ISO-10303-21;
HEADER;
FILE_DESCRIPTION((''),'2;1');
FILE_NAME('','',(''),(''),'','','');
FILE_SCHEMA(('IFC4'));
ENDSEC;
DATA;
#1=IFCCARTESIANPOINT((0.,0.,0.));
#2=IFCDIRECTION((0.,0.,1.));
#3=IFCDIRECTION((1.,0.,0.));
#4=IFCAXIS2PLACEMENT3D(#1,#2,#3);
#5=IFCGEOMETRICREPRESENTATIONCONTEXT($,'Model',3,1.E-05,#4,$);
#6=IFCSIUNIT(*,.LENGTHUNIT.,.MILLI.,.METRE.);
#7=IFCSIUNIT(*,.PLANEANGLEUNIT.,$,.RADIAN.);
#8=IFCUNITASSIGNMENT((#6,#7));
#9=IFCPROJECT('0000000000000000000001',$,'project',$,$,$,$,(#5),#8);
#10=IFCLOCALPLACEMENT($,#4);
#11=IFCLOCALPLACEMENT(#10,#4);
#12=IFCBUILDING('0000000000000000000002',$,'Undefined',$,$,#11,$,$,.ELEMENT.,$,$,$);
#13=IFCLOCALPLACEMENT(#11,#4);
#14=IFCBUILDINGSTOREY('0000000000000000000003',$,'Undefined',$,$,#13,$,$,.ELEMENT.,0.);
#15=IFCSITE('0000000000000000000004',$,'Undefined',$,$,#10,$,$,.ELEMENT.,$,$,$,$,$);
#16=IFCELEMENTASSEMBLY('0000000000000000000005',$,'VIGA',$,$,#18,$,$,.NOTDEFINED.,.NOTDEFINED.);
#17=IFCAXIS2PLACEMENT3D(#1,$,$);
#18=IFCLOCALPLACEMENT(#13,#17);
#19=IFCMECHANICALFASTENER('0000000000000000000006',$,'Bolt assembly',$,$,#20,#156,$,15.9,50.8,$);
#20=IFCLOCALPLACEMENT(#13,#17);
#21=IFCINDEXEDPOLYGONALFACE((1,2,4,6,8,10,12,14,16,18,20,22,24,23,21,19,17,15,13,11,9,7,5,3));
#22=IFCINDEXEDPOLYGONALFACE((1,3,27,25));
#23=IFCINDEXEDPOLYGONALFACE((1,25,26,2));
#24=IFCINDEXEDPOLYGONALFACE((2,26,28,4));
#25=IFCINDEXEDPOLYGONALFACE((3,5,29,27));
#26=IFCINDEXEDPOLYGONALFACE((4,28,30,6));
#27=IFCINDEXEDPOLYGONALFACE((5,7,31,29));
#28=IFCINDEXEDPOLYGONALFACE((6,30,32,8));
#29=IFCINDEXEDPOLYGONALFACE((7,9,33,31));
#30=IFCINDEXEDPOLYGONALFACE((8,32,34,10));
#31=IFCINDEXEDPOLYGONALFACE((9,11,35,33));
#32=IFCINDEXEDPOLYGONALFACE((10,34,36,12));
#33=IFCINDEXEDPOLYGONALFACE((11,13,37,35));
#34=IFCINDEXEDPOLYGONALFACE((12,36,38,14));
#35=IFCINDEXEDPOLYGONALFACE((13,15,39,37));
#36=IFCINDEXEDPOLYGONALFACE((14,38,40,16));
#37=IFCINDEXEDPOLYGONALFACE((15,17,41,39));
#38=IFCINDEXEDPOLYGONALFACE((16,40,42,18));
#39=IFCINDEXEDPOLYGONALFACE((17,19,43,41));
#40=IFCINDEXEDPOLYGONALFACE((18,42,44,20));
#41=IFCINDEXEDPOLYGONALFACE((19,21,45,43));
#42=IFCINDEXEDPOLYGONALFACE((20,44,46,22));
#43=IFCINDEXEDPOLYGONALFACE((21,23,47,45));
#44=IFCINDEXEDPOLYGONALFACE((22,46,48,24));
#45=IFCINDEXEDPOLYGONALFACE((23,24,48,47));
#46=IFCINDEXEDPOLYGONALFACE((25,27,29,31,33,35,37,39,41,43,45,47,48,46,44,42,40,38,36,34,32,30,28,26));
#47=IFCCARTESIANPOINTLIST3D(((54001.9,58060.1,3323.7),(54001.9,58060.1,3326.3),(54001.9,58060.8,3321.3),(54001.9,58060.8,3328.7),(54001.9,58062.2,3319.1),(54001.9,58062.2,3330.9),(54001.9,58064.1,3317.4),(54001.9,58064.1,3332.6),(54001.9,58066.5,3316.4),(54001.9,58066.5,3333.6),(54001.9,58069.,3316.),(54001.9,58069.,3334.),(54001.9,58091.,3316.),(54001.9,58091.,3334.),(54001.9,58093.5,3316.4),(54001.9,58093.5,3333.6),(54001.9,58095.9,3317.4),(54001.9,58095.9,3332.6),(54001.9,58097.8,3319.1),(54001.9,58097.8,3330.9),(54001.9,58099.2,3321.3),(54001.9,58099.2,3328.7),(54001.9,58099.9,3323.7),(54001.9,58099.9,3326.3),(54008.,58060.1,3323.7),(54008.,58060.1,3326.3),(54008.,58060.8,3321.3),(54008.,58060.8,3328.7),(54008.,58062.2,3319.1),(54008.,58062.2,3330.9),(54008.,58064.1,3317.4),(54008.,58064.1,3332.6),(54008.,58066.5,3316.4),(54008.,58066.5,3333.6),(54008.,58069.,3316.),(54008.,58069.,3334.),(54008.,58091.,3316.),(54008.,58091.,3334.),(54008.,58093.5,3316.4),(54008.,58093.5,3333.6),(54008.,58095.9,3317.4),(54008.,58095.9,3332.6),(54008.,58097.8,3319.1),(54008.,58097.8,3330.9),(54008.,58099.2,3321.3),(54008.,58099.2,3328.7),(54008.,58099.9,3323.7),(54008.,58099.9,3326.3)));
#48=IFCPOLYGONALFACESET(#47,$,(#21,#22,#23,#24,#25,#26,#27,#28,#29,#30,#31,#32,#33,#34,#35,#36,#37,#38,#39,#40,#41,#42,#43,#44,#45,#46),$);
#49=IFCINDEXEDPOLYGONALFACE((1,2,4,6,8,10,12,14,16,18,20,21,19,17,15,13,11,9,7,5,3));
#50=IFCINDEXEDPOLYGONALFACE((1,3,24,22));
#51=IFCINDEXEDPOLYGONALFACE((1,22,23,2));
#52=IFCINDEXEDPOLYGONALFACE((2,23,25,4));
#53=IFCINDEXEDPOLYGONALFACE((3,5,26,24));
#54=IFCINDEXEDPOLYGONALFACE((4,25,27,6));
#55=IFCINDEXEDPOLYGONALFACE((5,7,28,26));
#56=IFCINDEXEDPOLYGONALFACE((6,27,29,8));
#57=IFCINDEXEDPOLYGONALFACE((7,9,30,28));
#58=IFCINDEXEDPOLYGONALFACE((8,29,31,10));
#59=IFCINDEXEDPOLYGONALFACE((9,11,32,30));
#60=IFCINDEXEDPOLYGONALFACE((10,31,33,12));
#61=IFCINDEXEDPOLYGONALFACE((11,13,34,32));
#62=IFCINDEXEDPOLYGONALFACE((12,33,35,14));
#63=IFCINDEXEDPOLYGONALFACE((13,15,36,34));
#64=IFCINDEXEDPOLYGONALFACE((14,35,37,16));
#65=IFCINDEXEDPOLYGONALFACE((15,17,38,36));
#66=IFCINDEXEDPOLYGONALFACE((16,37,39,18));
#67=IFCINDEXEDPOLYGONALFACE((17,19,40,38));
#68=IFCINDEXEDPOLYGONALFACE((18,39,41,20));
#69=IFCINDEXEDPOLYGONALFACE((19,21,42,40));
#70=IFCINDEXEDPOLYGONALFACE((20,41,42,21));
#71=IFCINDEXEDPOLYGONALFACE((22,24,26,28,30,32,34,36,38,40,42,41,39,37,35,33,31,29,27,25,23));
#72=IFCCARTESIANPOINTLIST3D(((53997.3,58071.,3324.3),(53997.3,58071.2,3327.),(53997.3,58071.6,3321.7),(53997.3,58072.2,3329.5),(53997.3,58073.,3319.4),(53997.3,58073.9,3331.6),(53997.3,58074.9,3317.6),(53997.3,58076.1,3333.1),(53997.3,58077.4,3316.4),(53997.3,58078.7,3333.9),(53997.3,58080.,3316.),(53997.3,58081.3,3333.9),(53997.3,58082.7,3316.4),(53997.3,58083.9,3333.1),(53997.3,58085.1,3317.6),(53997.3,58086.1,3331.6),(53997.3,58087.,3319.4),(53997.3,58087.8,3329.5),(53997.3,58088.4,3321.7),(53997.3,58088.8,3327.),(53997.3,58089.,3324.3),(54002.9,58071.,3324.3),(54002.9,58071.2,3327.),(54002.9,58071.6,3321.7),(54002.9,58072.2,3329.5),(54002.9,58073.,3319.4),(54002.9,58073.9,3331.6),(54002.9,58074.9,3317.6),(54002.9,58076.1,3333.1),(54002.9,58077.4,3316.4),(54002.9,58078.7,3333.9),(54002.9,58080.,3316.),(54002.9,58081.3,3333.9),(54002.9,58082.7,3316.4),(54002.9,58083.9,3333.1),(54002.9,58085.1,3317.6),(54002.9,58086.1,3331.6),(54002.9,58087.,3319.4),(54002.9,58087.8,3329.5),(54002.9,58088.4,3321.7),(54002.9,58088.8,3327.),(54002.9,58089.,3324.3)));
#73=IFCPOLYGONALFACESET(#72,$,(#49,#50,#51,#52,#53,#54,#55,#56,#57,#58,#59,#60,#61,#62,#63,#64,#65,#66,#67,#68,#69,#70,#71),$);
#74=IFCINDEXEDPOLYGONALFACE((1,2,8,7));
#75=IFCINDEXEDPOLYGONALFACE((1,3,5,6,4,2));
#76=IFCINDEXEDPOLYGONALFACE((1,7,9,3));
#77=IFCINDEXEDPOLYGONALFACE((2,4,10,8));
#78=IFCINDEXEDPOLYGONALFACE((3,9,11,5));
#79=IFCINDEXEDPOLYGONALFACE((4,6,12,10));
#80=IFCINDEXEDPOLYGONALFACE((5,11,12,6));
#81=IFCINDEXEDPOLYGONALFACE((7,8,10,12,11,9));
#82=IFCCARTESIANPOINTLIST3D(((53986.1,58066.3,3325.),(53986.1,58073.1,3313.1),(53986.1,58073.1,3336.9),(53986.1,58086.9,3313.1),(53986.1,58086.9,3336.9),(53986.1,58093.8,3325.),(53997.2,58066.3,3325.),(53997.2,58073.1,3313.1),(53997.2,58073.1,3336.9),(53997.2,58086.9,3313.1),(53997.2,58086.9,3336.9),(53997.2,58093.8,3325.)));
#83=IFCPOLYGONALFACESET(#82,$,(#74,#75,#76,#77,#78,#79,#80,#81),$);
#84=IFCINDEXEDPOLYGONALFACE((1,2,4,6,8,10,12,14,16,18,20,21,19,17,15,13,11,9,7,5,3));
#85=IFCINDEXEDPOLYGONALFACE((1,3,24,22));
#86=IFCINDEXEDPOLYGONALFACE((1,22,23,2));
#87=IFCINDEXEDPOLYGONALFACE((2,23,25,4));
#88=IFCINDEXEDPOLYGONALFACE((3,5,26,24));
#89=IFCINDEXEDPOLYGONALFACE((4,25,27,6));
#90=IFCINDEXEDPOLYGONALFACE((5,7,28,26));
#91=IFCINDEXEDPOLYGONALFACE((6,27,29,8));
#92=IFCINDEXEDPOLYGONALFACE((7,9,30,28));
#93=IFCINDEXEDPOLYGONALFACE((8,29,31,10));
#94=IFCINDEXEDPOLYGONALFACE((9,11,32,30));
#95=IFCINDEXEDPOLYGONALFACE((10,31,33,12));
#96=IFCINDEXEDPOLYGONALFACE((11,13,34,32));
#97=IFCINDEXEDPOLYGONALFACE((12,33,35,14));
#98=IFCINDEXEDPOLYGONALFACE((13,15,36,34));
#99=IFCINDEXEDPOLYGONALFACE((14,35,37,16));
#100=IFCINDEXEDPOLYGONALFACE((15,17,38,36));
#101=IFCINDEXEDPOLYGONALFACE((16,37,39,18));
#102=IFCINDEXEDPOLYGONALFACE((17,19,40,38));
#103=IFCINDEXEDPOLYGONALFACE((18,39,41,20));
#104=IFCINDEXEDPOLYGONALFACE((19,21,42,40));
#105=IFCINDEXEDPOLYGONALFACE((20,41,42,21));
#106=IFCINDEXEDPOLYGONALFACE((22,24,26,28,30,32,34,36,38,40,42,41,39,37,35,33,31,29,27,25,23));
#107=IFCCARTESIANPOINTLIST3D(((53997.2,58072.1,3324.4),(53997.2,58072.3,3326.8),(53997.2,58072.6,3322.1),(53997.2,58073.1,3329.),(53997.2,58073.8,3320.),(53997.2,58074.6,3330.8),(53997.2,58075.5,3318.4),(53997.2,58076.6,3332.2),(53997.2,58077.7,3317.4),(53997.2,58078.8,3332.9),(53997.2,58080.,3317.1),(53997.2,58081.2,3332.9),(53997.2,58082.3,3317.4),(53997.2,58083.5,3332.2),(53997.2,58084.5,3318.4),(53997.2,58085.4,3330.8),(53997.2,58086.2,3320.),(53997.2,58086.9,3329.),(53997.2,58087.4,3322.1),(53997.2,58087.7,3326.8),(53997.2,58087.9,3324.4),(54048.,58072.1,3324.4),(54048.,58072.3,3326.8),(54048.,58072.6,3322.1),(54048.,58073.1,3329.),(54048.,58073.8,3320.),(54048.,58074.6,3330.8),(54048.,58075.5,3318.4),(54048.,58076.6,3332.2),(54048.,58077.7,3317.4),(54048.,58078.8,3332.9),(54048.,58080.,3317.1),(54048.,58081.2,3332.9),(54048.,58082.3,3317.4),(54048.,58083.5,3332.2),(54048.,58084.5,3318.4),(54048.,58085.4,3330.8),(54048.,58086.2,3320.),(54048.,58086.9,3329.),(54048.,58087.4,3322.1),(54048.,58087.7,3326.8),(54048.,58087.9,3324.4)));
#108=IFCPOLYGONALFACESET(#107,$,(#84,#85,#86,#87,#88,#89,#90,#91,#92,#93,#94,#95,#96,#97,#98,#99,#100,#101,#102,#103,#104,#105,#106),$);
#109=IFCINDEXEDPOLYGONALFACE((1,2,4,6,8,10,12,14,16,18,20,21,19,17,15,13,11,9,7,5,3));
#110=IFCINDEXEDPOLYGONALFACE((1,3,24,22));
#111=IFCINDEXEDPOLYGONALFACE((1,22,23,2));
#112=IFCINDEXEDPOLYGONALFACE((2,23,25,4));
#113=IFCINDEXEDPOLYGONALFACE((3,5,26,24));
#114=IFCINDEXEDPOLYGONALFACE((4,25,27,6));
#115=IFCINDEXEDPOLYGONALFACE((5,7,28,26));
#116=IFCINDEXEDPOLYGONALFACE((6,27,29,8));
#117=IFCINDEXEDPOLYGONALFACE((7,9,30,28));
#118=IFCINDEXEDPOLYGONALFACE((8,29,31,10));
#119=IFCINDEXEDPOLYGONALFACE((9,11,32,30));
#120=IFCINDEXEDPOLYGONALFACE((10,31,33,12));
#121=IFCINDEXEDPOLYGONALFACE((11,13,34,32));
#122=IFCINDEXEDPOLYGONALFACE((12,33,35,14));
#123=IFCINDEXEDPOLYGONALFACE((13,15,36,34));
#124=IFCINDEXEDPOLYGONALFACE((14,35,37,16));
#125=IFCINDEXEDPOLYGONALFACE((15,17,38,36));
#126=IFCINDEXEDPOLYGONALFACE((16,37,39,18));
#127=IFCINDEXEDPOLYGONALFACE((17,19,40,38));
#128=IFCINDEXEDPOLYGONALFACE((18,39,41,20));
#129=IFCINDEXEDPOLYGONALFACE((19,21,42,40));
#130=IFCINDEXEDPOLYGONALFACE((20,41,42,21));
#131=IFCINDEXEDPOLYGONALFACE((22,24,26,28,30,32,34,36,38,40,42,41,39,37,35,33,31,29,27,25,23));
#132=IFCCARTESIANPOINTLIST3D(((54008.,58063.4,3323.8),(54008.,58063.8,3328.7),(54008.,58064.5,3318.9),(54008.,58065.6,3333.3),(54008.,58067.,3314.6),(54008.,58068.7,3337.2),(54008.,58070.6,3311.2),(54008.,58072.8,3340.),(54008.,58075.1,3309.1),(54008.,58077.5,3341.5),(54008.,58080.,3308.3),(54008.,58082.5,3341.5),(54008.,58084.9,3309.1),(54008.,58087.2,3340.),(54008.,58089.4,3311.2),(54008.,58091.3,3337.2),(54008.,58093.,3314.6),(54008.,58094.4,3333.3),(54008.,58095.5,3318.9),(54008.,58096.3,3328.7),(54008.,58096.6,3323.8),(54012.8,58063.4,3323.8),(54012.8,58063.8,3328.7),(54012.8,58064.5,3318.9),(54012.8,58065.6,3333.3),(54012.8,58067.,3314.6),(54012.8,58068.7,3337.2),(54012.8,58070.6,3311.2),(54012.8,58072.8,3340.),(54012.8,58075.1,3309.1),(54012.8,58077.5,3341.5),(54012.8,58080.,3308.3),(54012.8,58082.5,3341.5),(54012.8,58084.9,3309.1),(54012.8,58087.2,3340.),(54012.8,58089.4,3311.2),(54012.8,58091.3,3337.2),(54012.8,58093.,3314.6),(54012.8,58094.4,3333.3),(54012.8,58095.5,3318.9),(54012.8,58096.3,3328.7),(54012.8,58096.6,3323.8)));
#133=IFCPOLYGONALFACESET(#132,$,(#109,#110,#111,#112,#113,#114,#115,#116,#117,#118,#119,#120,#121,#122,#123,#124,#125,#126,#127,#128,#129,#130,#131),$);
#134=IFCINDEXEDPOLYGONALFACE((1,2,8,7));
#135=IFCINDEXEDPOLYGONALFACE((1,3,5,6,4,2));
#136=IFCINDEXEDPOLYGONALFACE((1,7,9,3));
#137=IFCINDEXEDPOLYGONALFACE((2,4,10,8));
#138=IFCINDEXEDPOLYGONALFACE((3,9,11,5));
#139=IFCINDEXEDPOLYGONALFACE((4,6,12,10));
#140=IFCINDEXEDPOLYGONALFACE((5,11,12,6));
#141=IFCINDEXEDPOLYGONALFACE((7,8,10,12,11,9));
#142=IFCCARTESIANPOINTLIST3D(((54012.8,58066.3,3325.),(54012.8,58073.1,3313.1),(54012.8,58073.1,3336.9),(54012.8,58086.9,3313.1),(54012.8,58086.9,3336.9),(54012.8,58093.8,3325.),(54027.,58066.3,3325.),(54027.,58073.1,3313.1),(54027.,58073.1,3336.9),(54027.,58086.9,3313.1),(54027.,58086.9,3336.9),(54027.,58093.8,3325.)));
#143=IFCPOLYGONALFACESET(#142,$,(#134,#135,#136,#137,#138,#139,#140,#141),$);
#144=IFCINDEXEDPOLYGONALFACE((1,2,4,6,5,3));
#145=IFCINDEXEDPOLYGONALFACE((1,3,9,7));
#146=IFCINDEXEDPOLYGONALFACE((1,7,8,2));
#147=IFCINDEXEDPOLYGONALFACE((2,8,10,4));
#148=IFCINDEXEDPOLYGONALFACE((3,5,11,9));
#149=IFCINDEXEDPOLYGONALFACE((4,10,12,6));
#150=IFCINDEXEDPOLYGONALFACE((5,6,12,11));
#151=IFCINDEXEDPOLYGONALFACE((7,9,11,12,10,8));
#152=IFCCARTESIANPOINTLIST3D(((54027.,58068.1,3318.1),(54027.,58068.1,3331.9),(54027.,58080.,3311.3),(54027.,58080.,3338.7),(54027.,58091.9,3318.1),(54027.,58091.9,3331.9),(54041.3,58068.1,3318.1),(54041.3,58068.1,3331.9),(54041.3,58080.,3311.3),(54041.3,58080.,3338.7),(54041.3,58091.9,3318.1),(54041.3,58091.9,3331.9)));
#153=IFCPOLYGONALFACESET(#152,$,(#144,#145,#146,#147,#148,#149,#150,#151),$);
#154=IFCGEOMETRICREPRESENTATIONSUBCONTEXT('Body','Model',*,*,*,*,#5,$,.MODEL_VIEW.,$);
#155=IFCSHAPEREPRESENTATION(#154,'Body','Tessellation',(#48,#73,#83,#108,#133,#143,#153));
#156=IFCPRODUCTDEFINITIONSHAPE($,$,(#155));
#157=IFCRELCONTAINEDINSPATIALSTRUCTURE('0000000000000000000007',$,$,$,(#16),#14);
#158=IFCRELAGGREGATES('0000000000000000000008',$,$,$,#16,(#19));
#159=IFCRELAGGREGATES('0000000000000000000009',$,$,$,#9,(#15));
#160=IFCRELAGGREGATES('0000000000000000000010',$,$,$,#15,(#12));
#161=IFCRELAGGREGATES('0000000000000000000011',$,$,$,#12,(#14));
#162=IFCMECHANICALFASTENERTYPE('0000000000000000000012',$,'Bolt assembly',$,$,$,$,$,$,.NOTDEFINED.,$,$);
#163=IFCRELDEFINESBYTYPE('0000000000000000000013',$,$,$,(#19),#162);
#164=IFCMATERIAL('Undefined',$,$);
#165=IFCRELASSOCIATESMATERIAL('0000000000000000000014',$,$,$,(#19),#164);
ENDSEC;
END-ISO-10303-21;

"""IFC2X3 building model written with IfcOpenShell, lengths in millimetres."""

from ifc_helpers import new_model, si_unit, frame, frame_2d, origin_with_axes, origin_2d_with_axis, place, context, subcontext, project, spatial, polyline, circle_curve, parameter, trimmed, segment, composite_curve, circle, outline, extrude, source, transform, mapped, material, type_object, element, aggregate, save


model = new_model("IFC2X3")

# Units and contexts
model_context = context("Model", 3, precision=1e-05, world=origin_with_axes())
body_context = subcontext(model_context, "Body", "Model", "MODEL_VIEW")
ifc_project = project(units=[si_unit("LENGTHUNIT", "METRE", prefix="MILLI"), si_unit("PLANEANGLEUNIT", "RADIAN")], contexts=[model_context])

# Site, building, storey
site_placement = place(None, origin_with_axes())
site = spatial("IfcSite", under=ifc_project, at=site_placement, Name="Undefined", CompositionType="ELEMENT")
building_placement = place(site_placement, origin_with_axes())
building = spatial("IfcBuilding", under=site, at=building_placement, Name="Undefined", CompositionType="ELEMENT")
storey_placement = place(building_placement, origin_with_axes())
storey = spatial("IfcBuildingStorey", under=building, at=storey_placement, Name="Undefined", CompositionType="ELEMENT", Elevation=0.0)

# Element assembly
assembly_1_placement = place(storey_placement, origin_with_axes())
assembly_1 = element("IfcElementAssembly", 1, at=assembly_1_placement, inside=storey, Name="VIGA", AssemblyPlace="NOTDEFINED", PredefinedType="NOTDEFINED")

# Shared definitions
mechanical_fastener_type = type_object("IfcMechanicalFastenerType", Name="Bolt assembly")

# Mechanical fastener
ifc_material_1 = material(Name="Undefined")
shared_shape_1 = source(origin_with_axes(), body_context, "Body", "SweptSolid", [
    extrude(outline(composite_curve([segment(polyline([(9.0, 11.0), (9.0, -11.0)]), True, "CONTINUOUS"), segment(trimmed(circle_curve(frame_2d((0.0, -11.0), x_axis=(1.0, 0.0)), 9.0), [parameter(0.0)], [parameter(3.141593)], False, "PARAMETER"), True, "CONTINUOUS"), segment(polyline([(-9.0, -11.0), (-9.0, 11.0)]), True, "CONTINUOUS"), segment(trimmed(circle_curve(frame_2d((0.0, 11.0), x_axis=(-1.0, 0.0)), 9.0), [parameter(0.0)], [parameter(3.141593)], False, "PARAMETER"), True, "DISCONTINUOUS")], self_intersect=False)), frame((0.0, 1.9, 0.0), z_axis=(0.0, 1.0, 0.0), x_axis=(1.0, 0.0, 0.0)), (0.0, 0.0, 1.0), 6.1),
    extrude(circle(Radius=9.0, at=origin_2d_with_axis()), frame((0.0, -2.7, 0.0), z_axis=(0.0, 1.0, 0.0), x_axis=(1.0, 0.0, 0.0)), (0.0, 0.0, 1.0), 5.6),
    extrude(outline(polyline([(11.9, -6.9), (11.9, 6.9), (0.0, 13.7), (-11.9, 6.9), (-11.9, -6.9), (0.0, -13.7), (11.9, -6.9)])), frame((0.0, -13.9, 0.0), z_axis=(0.0, 1.0, 0.0), x_axis=(1.0, 0.0, 0.0)), (0.0, 0.0, 1.0), 11.1),
    extrude(circle(Radius=7.9, at=origin_2d_with_axis()), frame((0.0, -2.8, 0.0), z_axis=(0.0, 1.0, 0.0), x_axis=(1.0, 0.0, 0.0)), (0.0, 0.0, 1.0), 50.8),
    extrude(circle(Radius=16.7, at=origin_2d_with_axis()), frame((0.0, 8.0, 0.0), z_axis=(0.0, 1.0, 0.0), x_axis=(1.0, 0.0, 0.0)), (0.0, 0.0, 1.0), 4.8),
    extrude(outline(polyline([(11.9, -6.9), (11.9, 6.9), (0.0, 13.7), (-11.9, 6.9), (-11.9, -6.9), (0.0, -13.7), (11.9, -6.9)])), frame((0.0, 12.8, 0.0), z_axis=(0.0, 1.0, 0.0), x_axis=(1.0, 0.0, 0.0)), (0.0, 0.0, 1.0), 14.3),
    extrude(outline(polyline([(13.7, 0.0), (6.9, 11.9), (-6.9, 11.9), (-13.7, 0.0), (-6.9, -11.9), (6.9, -11.9), (13.7, 0.0)])), frame((0.0, 27.0, 0.0), z_axis=(0.0, 1.0, 0.0), x_axis=(1.0, 0.0, 0.0)), (0.0, 0.0, 1.0), 14.3),
])
mechanical_fastener_1_placement = place(assembly_1_placement, frame((54000.0, 58080.0, 3325.0), z_axis=(0.0, -1.0, 0.0), x_axis=(0.0, 0.0, -1.0)))
mechanical_fastener_1 = element("IfcMechanicalFastener", 2, at=mechanical_fastener_1_placement, type_object=mechanical_fastener_type, material=ifc_material_1, Name="Bolt assembly", NominalDiameter=15.9, NominalLength=50.8, context=body_context, shape_type="MappedRepresentation", body=[
    mapped(shared_shape_1, transform((0.0, 0.0, 0.0))),
])
aggregate(assembly_1, [mechanical_fastener_1])

save(model, "model.ifc")
